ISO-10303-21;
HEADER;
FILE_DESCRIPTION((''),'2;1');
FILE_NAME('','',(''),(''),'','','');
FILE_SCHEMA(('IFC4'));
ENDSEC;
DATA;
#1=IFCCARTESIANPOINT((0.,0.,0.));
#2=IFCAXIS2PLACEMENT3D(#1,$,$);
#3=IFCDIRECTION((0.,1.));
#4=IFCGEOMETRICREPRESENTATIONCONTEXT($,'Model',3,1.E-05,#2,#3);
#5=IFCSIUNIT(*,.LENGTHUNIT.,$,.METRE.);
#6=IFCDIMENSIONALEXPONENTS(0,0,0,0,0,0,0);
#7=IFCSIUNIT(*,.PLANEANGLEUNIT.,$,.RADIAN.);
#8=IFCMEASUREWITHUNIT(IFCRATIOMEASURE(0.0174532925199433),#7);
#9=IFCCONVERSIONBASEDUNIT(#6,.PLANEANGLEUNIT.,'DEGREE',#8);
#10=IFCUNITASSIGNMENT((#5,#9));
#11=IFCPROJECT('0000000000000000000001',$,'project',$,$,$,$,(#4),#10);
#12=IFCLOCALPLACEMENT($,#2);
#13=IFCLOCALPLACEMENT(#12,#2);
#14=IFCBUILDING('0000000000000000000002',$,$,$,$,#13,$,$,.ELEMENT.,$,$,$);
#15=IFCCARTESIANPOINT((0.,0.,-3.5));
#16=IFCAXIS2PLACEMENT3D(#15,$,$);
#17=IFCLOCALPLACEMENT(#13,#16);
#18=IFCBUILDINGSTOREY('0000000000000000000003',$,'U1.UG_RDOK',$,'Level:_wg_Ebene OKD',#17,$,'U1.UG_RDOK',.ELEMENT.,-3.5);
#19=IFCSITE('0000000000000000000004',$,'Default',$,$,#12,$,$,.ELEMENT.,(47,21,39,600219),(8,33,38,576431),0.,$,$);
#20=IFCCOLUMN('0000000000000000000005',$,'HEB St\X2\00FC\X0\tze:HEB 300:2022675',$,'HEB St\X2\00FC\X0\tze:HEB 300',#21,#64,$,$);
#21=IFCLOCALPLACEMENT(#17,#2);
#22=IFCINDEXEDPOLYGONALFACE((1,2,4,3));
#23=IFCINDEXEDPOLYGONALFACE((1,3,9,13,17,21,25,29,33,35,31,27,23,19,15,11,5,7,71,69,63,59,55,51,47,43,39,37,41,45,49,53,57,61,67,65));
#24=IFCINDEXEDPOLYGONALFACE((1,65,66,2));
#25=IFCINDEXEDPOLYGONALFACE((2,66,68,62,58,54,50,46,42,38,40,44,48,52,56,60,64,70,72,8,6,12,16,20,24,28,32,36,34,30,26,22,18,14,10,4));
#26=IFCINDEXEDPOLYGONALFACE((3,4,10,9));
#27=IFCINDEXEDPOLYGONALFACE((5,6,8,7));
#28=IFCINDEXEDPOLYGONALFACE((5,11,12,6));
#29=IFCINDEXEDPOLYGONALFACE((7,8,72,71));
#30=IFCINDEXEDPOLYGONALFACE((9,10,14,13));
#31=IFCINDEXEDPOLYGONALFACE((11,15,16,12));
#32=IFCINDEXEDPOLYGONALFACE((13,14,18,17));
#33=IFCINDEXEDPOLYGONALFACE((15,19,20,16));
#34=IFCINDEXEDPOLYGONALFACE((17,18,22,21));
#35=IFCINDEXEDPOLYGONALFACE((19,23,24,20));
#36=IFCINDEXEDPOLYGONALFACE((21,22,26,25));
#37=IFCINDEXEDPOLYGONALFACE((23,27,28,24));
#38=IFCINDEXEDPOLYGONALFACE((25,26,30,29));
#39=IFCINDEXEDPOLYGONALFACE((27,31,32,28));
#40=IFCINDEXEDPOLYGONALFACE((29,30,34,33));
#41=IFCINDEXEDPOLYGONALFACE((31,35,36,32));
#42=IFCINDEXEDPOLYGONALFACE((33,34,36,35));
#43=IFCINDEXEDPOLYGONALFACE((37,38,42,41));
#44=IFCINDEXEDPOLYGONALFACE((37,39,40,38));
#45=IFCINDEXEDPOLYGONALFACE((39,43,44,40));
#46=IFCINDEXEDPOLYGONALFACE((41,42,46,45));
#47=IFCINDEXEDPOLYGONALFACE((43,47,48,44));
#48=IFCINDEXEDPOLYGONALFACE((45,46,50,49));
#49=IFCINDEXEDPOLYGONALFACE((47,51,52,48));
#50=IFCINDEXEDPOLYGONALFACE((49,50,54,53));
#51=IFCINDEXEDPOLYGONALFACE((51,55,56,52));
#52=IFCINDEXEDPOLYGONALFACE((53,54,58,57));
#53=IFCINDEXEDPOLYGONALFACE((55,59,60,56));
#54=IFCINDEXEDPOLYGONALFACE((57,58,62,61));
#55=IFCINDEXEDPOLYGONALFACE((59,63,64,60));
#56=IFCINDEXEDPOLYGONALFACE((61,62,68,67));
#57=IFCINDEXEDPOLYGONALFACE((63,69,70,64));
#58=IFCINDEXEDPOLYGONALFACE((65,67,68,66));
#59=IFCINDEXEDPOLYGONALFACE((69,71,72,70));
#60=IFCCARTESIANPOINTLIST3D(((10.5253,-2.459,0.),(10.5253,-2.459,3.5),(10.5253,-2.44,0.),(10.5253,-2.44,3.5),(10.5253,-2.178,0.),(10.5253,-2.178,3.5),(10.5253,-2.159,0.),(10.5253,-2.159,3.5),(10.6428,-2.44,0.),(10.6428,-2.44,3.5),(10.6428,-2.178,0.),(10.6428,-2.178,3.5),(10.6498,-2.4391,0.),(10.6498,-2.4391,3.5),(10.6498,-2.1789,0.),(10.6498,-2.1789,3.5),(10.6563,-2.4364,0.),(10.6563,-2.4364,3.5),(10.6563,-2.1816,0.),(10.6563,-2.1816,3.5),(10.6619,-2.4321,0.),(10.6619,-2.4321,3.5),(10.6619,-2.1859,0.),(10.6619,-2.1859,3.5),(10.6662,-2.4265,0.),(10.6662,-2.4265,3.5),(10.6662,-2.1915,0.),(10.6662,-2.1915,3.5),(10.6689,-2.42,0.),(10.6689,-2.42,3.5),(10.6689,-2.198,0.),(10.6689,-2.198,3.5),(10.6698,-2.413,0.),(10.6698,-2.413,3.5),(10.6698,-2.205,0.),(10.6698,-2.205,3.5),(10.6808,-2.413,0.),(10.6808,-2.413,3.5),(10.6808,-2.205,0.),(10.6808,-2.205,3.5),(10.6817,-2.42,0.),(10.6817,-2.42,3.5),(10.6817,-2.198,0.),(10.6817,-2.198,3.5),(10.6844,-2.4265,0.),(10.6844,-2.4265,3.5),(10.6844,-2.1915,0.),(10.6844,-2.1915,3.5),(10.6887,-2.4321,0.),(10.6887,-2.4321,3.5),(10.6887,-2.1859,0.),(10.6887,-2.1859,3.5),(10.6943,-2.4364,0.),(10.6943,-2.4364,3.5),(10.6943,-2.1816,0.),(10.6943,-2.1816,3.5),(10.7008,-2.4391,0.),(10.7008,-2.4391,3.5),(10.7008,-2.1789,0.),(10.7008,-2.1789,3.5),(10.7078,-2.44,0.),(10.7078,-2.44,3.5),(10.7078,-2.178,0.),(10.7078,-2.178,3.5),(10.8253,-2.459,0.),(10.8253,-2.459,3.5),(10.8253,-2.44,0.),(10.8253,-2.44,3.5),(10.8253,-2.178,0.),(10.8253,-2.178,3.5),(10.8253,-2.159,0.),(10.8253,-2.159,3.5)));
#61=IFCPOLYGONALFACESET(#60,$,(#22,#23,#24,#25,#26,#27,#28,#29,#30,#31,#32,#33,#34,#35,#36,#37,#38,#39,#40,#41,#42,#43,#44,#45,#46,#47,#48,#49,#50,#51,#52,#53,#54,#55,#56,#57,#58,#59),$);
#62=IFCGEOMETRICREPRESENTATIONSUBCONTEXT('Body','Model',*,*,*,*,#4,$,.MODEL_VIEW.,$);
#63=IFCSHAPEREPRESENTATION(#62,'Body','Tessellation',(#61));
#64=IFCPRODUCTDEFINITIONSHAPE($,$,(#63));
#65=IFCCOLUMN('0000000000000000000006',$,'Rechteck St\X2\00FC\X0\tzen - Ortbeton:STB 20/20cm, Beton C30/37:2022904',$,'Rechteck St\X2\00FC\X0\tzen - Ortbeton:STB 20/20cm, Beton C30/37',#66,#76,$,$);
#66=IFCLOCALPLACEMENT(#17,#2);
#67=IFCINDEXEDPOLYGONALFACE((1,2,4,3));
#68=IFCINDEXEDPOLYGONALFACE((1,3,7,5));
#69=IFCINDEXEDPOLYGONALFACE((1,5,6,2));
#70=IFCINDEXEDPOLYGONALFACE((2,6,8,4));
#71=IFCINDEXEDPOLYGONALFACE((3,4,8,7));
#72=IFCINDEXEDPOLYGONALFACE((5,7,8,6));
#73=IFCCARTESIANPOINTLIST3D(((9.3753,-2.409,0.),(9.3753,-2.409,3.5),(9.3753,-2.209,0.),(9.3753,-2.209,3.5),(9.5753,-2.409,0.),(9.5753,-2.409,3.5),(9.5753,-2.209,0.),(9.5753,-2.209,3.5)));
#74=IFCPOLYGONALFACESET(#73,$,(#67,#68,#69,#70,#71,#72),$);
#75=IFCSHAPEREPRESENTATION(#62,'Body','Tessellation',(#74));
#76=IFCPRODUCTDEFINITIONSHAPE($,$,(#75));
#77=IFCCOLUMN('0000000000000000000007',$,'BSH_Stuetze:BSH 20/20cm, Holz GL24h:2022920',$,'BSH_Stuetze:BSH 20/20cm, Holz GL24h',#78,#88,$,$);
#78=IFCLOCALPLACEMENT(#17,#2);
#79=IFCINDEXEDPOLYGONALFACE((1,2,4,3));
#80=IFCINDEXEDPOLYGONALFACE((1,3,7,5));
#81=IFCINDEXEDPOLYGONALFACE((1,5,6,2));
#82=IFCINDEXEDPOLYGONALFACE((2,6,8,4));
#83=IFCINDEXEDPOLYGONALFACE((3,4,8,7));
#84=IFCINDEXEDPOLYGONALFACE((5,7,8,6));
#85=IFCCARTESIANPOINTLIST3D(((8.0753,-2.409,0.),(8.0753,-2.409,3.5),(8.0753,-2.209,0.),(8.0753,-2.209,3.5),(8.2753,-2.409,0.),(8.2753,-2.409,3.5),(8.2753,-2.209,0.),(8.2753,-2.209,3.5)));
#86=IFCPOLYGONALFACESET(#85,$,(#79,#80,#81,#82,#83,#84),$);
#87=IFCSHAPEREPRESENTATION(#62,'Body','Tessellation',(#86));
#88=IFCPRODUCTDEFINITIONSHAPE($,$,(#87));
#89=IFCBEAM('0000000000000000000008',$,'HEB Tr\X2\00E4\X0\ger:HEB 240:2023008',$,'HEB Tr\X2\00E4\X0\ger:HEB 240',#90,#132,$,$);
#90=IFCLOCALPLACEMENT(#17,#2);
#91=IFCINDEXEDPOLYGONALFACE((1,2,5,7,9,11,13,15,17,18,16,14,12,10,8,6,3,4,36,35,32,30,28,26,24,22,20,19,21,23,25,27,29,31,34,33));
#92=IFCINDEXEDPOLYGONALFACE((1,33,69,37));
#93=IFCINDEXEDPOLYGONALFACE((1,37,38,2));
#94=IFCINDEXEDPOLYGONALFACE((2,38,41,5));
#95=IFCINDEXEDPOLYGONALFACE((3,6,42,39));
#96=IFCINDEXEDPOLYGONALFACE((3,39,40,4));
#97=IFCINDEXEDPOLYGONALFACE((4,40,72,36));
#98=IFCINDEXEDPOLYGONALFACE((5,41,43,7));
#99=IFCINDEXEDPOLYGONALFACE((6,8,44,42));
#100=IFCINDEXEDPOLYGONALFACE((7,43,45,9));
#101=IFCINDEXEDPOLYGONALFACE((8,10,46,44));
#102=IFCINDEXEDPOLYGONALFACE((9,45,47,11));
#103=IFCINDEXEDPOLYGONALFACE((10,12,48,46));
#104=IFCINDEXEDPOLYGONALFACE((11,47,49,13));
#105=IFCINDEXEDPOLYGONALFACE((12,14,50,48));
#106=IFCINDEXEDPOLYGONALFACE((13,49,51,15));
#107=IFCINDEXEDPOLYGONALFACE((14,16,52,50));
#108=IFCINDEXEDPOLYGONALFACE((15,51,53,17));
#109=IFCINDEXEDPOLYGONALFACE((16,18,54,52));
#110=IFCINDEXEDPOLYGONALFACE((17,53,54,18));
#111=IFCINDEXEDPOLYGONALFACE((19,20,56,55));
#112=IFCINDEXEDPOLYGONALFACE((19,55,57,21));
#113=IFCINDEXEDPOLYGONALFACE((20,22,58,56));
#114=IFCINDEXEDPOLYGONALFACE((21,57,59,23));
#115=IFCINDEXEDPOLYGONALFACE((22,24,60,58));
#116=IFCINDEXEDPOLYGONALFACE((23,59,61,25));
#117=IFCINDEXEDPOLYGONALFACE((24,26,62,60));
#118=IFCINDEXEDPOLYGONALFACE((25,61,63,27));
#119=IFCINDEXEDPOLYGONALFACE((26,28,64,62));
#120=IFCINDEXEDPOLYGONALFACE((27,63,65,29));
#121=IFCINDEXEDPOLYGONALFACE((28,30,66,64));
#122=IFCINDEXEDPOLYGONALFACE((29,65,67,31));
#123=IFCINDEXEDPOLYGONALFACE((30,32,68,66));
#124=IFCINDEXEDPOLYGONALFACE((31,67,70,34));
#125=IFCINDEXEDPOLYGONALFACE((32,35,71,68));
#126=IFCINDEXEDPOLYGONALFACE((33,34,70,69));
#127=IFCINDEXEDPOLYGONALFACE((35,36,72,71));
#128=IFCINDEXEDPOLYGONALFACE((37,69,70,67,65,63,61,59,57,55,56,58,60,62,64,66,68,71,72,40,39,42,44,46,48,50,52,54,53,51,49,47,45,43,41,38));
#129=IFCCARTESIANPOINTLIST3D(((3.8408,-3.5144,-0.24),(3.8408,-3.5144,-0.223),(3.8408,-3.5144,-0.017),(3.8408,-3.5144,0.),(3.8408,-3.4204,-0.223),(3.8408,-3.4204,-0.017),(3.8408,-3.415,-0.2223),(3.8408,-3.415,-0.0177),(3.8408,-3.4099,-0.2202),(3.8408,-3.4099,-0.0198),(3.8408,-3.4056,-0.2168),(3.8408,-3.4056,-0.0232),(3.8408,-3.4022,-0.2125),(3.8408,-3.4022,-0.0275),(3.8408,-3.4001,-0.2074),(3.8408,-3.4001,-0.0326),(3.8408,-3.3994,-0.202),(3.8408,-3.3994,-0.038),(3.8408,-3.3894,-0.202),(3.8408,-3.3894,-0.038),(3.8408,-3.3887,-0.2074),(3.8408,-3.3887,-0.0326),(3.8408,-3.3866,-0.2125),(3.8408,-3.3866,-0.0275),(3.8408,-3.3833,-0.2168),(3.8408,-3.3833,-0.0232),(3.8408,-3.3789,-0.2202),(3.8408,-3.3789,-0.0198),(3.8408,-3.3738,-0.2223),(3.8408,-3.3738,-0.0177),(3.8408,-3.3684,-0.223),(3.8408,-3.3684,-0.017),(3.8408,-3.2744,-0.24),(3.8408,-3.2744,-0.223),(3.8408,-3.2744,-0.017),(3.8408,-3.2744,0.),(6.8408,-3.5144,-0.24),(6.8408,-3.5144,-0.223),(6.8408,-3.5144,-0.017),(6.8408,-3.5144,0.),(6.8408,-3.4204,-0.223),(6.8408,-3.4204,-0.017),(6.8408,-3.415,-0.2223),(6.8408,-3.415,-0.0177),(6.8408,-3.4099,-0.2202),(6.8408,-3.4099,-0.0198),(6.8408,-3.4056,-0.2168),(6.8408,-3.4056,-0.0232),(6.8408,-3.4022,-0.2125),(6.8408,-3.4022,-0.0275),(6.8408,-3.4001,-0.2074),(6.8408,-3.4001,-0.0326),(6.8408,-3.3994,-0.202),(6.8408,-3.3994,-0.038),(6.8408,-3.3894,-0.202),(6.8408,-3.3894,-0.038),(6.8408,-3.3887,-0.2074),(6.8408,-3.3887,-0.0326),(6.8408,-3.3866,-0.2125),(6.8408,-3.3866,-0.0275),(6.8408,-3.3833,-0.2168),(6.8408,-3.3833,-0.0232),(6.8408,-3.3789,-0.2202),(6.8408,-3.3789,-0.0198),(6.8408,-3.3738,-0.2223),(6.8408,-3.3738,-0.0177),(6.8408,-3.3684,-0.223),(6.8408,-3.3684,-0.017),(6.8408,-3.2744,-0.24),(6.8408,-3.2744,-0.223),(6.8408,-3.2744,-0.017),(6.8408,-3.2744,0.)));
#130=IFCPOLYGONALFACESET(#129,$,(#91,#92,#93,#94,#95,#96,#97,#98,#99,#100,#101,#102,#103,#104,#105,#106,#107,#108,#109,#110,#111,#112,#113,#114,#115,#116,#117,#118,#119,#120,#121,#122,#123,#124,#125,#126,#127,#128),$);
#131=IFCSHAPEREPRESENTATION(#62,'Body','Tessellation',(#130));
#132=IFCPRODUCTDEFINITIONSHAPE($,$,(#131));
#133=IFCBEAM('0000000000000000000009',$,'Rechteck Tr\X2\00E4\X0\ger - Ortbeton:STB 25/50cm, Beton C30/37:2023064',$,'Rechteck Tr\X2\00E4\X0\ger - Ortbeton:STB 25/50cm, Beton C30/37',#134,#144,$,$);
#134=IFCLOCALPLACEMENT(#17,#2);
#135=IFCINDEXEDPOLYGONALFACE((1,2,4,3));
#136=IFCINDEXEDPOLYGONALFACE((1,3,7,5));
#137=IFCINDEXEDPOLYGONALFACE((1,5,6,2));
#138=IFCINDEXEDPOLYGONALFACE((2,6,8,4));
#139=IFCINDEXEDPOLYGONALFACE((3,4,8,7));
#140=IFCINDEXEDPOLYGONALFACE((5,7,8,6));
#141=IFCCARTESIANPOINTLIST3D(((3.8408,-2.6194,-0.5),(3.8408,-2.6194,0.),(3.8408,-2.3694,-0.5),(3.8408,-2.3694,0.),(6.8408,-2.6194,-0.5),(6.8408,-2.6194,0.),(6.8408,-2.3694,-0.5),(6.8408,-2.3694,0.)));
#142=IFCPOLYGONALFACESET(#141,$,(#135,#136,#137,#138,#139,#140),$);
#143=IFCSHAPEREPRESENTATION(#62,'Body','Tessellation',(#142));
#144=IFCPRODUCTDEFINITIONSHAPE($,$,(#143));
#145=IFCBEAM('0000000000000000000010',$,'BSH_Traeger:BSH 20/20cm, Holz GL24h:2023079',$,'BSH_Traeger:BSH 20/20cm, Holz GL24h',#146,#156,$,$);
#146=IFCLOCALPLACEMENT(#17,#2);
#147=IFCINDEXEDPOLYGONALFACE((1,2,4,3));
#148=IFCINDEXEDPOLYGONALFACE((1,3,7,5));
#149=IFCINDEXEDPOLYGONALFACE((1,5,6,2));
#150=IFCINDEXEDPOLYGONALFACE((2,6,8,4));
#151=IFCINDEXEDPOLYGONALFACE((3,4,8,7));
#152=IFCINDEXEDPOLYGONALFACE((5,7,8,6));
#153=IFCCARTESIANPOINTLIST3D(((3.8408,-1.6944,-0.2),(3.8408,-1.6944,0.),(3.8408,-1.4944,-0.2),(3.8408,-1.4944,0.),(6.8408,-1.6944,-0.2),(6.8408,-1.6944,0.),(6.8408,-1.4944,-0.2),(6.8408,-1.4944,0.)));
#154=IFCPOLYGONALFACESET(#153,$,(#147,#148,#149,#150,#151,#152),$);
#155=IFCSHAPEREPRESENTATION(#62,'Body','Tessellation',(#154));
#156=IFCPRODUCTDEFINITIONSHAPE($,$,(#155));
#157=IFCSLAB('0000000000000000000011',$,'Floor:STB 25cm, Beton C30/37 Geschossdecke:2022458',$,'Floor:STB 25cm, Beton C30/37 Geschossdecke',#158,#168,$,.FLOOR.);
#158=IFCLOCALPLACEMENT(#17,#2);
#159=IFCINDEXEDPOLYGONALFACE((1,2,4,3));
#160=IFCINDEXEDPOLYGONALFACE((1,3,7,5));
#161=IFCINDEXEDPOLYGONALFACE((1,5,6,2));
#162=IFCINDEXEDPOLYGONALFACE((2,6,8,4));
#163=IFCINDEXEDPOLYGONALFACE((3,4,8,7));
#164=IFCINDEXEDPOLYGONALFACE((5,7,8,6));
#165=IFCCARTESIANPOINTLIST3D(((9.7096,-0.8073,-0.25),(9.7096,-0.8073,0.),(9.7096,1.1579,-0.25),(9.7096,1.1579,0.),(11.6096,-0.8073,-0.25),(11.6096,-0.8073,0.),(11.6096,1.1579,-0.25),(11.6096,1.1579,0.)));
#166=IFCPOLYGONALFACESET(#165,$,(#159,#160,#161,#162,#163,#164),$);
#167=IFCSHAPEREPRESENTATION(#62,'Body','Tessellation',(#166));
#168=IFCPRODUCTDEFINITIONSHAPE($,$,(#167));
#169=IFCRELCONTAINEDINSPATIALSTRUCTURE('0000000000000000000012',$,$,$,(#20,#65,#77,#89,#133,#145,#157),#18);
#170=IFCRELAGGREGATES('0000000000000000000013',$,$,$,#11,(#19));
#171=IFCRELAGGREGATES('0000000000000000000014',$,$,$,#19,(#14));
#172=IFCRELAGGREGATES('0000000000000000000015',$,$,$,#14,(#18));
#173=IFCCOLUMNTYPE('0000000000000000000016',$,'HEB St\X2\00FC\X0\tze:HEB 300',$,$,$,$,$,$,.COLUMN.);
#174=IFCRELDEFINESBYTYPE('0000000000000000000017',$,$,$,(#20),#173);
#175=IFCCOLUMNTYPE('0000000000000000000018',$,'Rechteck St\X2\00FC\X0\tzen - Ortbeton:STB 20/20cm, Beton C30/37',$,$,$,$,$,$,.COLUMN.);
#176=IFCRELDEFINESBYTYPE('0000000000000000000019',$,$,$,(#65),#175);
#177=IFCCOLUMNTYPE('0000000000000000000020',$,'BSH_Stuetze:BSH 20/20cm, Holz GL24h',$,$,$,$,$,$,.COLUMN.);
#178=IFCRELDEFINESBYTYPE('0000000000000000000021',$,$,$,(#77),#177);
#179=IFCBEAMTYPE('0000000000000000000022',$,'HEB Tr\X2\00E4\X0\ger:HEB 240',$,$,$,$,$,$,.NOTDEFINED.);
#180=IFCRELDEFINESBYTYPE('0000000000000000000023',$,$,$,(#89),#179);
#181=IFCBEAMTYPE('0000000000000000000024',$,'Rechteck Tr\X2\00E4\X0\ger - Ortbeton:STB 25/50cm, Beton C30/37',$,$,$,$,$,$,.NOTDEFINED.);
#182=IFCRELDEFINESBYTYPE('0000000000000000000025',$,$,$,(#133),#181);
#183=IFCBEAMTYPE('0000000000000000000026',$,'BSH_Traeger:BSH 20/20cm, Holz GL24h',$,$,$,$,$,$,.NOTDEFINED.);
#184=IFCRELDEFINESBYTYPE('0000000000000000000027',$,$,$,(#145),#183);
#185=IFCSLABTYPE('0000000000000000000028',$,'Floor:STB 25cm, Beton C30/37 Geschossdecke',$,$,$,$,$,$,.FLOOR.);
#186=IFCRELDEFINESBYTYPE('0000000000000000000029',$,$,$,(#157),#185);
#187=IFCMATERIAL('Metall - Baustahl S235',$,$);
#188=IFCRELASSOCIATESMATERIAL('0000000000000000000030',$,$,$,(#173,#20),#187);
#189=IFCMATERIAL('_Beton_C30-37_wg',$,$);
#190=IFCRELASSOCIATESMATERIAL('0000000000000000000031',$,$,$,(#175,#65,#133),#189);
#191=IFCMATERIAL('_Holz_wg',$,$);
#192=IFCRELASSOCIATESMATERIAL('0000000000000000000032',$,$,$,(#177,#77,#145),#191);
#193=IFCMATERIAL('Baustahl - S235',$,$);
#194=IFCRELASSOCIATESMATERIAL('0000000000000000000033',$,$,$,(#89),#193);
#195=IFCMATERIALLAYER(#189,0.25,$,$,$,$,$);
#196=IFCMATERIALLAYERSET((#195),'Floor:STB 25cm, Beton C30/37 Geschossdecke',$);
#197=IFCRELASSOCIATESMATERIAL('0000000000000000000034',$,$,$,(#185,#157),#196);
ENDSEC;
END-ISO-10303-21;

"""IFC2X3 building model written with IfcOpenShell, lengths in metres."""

from ifc_helpers import new_model, entity, si_unit, converted_unit, direction, frame, frame_2d, origin, origin_2d_with_axis, place, context, subcontext, project, spatial, polyline, circle_curve, parameter, trimmed, segment, composite_curve, rectangle, i_section, outline, extrude, source, transform, mapped, material, layer, layer_set, layer_usage, type_object, type_shapes, element, save


model = new_model("IFC2X3")

# Units and contexts
model_context = context("Model", 3, precision=1e-05, world=origin(), true_north=direction((0.0, 1.0)))
body_context = subcontext(model_context, "Body", "Model", "MODEL_VIEW")
ifc_project = project(units=[si_unit("LENGTHUNIT", "METRE"), converted_unit("PLANEANGLEUNIT", "DEGREE", entity("IfcRatioMeasure", 0.0174532925199433), si_unit("PLANEANGLEUNIT", "RADIAN"), dimensions=[0, 0, 0, 0, 0, 0, 0])], contexts=[model_context])

# Site, building, storey
site_placement = place(None, origin())
site = spatial("IfcSite", under=ifc_project, at=site_placement, Name="Default", CompositionType="ELEMENT", RefLatitude=(47, 21, 39, 600219), RefLongitude=(8, 33, 38, 576431), RefElevation=0.0)
building_placement = place(site_placement, origin())
building = spatial("IfcBuilding", under=site, at=building_placement, CompositionType="ELEMENT")
storey_placement = place(building_placement, frame((0.0, 0.0, -3.5)))
storey = spatial("IfcBuildingStorey", under=building, at=storey_placement, Name="U1.UG_RDOK", ObjectType="Level:_wg_Ebene OKD", LongName="U1.UG_RDOK", CompositionType="ELEMENT", Elevation=-3.5)

# Columns
ifc_material_1 = material(Name="Metall - Baustahl S235")
column_type_1 = type_object("IfcColumnType", Name="HEB Stütze:HEB 300", PredefinedType="COLUMN", material=ifc_material_1)
shared_shape_1 = source(origin(), body_context, "Body", "SweptSolid", [
    extrude(outline(composite_curve([segment(polyline([(0.131, -0.15), (0.15, -0.15)]), True, "CONTINUOUS"), segment(polyline([(0.15, -0.15), (0.15, 0.15)]), True, "CONTINUOUS"), segment(polyline([(0.15, 0.15), (0.131, 0.15)]), True, "CONTINUOUS"), segment(polyline([(0.131, 0.15), (0.131, 0.0325)]), True, "CONTINUOUS"), segment(trimmed(circle_curve(frame_2d((0.104, 0.0325), x_axis=(1.0, 0.0)), 0.027), [parameter(270.0)], [parameter(0.0)], True, "PARAMETER"), False, "CONTINUOUS"), segment(polyline([(0.104, 0.0055), (-0.104, 0.0055)]), True, "CONTINUOUS"), segment(trimmed(circle_curve(frame_2d((-0.104, 0.0325), x_axis=(0.0, -1.0)), 0.027), [parameter(270.0)], [parameter(0.0)], True, "PARAMETER"), False, "CONTINUOUS"), segment(polyline([(-0.131, 0.0325), (-0.131, 0.15)]), True, "CONTINUOUS"), segment(polyline([(-0.131, 0.15), (-0.15, 0.15)]), True, "CONTINUOUS"), segment(polyline([(-0.15, 0.15), (-0.15, -0.15)]), True, "CONTINUOUS"), segment(polyline([(-0.15, -0.15), (-0.131, -0.15)]), True, "CONTINUOUS"), segment(polyline([(-0.131, -0.15), (-0.131, -0.0325)]), True, "CONTINUOUS"), segment(trimmed(circle_curve(frame_2d((-0.104, -0.0325), x_axis=(-1.0, 0.0)), 0.027), [parameter(270.0)], [parameter(0.0)], True, "PARAMETER"), False, "CONTINUOUS"), segment(polyline([(-0.104, -0.0055), (0.104, -0.0055)]), True, "CONTINUOUS"), segment(trimmed(circle_curve(frame_2d((0.104, -0.0325), x_axis=(0.0, 1.0)), 0.027), [parameter(270.0)], [parameter(0.0)], True, "PARAMETER"), False, "CONTINUOUS"), segment(polyline([(0.131, -0.0325), (0.131, -0.15)]), True, "CONTINUOUS")], self_intersect=False)), frame((0.0, 0.0, -3.5), z_axis=(0.0, 0.0, 1.0), x_axis=(0.0, -1.0, 0.0)), (0.0, 0.0, 1.0), 3.5),
])
type_shapes(column_type_1, [shared_shape_1])
column_1_placement = place(storey_placement, frame((10.6753, -2.309, 3.5)))
element("IfcColumn", 1, at=column_1_placement, inside=storey, type_object=column_type_1, material=ifc_material_1, Name="HEB Stütze:HEB 300:2022675", ObjectType="HEB Stütze:HEB 300", context=body_context, shape_type="MappedRepresentation", body=[
    mapped(shared_shape_1, transform((0.0, 0.0, 0.0), scale=1.0)),
])
ifc_material_2 = material(Name="_Beton_C30-37_wg")
column_type_2 = type_object("IfcColumnType", Name="Rechteck Stützen - Ortbeton:STB 20/20cm, Beton C30/37", PredefinedType="COLUMN", material=ifc_material_2)
shared_shape_2 = source(origin(), body_context, "Body", "SweptSolid", [
    extrude(rectangle(XDim=0.2, YDim=0.2, at=origin_2d_with_axis()), frame((0.0, 0.0, -3.5), z_axis=(0.0, 0.0, 1.0), x_axis=(0.0, -1.0, 0.0)), (0.0, 0.0, 1.0), 3.5),
])
type_shapes(column_type_2, [shared_shape_2])
column_2_placement = place(storey_placement, frame((9.4753, -2.309, 3.5)))
element("IfcColumn", 2, at=column_2_placement, inside=storey, type_object=column_type_2, material=ifc_material_2, Name="Rechteck Stützen - Ortbeton:STB 20/20cm, Beton C30/37:2022904", ObjectType="Rechteck Stützen - Ortbeton:STB 20/20cm, Beton C30/37", context=body_context, shape_type="MappedRepresentation", body=[
    mapped(shared_shape_2, transform((0.0, 0.0, 0.0), scale=1.0)),
])
ifc_material_3 = material(Name="_Holz_wg")
column_type_3 = type_object("IfcColumnType", Name="BSH_Stuetze:BSH 20/20cm, Holz GL24h", PredefinedType="COLUMN", material=ifc_material_3)
shared_shape_3 = source(origin(), body_context, "Body", "SweptSolid", [
    extrude(rectangle(XDim=0.2, YDim=0.2, at=origin_2d_with_axis()), frame((0.0, 0.0, -3.5), z_axis=(0.0, 0.0, 1.0), x_axis=(0.0, -1.0, 0.0)), (0.0, 0.0, 1.0), 3.5),
])
type_shapes(column_type_3, [shared_shape_3])
column_3_placement = place(storey_placement, frame((8.1753, -2.309, 3.5)))
element("IfcColumn", 3, at=column_3_placement, inside=storey, type_object=column_type_3, material=ifc_material_3, Name="BSH_Stuetze:BSH 20/20cm, Holz GL24h:2022920", ObjectType="BSH_Stuetze:BSH 20/20cm, Holz GL24h", context=body_context, shape_type="MappedRepresentation", body=[
    mapped(shared_shape_3, transform((0.0, 0.0, 0.0), scale=1.0)),
])

# Beams
ifc_material_4 = material(Name="Baustahl - S235")
beam_type_1 = type_object("IfcBeamType", Name="HEB Träger:HEB 240", PredefinedType="NOTDEFINED")
beam_1_placement = place(storey_placement, frame((6.8408, -3.3944, 0.0), z_axis=(0.0, 0.0, 1.0), x_axis=(-1.0, 0.0, 0.0)))
element("IfcBeam", 4, at=beam_1_placement, inside=storey, type_object=beam_type_1, material=ifc_material_4, Name="HEB Träger:HEB 240:2023008", ObjectType="HEB Träger:HEB 240", context=body_context, shape_type="SweptSolid", body=[
    extrude(i_section(OverallWidth=0.24, OverallDepth=0.24, WebThickness=0.01, FlangeThickness=0.017, FilletRadius=0.021, at=frame_2d((0.0, 0.0), x_axis=(0.0, 1.0))), frame((0.0, 0.0, -0.12), z_axis=(1.0, 0.0, 0.0), x_axis=(0.0, 0.0, -1.0)), (0.0, 0.0, 1.0), 3.0),
])
beam_type_2 = type_object("IfcBeamType", Name="Rechteck Träger - Ortbeton:STB 25/50cm, Beton C30/37", PredefinedType="NOTDEFINED")
beam_2_placement = place(storey_placement, frame((6.8408, -2.4944, 0.0), z_axis=(0.0, 0.0, 1.0), x_axis=(-1.0, 0.0, 0.0)))
element("IfcBeam", 5, at=beam_2_placement, inside=storey, type_object=beam_type_2, material=ifc_material_2, Name="Rechteck Träger - Ortbeton:STB 25/50cm, Beton C30/37:2023064", ObjectType="Rechteck Träger - Ortbeton:STB 25/50cm, Beton C30/37", context=body_context, shape_type="SweptSolid", body=[
    extrude(rectangle(XDim=0.5, YDim=0.25, at=frame_2d((0.0, 0.0), x_axis=(1.0, 0.0))), frame((0.0, 0.0, -0.25), z_axis=(1.0, 0.0, 0.0), x_axis=(0.0, 0.0, -1.0)), (0.0, 0.0, 1.0), 3.0),
])
beam_type_3 = type_object("IfcBeamType", Name="BSH_Traeger:BSH 20/20cm, Holz GL24h", PredefinedType="NOTDEFINED")
beam_3_placement = place(storey_placement, frame((6.8408, -1.5944, 0.0), z_axis=(0.0, 0.0, 1.0), x_axis=(-1.0, 0.0, 0.0)))
element("IfcBeam", 6, at=beam_3_placement, inside=storey, type_object=beam_type_3, material=ifc_material_3, Name="BSH_Traeger:BSH 20/20cm, Holz GL24h:2023079", ObjectType="BSH_Traeger:BSH 20/20cm, Holz GL24h", context=body_context, shape_type="SweptSolid", body=[
    extrude(rectangle(XDim=0.2, YDim=0.2, at=frame_2d((0.0, 0.0), x_axis=(1.0, 0.0))), frame((0.0, 0.0, -0.1), z_axis=(1.0, 0.0, 0.0), x_axis=(0.0, 0.0, -1.0)), (0.0, 0.0, 1.0), 3.0),
])

# Slab
ifc_layer_1 = layer(ifc_material_2, 0.25)
ifc_layer_set_1 = layer_set([ifc_layer_1], Name="Floor:STB 25cm, Beton C30/37 Geschossdecke")
ifc_layer_usage_1 = layer_usage(ifc_layer_set_1, "AXIS3", "POSITIVE", 0.0)
slab_type_1 = type_object("IfcSlabType", Name="Floor:STB 25cm, Beton C30/37 Geschossdecke", PredefinedType="FLOOR", material=ifc_layer_set_1)
slab_1_placement = place(storey_placement, origin())
element("IfcSlab", 7, at=slab_1_placement, inside=storey, type_object=slab_type_1, material=ifc_layer_usage_1, Name="Floor:STB 25cm, Beton C30/37 Geschossdecke:2022458", ObjectType="Floor:STB 25cm, Beton C30/37 Geschossdecke", PredefinedType="FLOOR", context=body_context, shape_type="SweptSolid", body=[
    extrude(rectangle(XDim=1.9652, YDim=1.9, at=frame_2d((0.0, 0.0), x_axis=(1.0, 0.0))), frame((10.6596, 0.1753, 0.0), z_axis=(0.0, 0.0, -1.0), x_axis=(0.0, 1.0, 0.0)), (0.0, 0.0, 1.0), 0.25),
])

save(model, "model.ifc")
